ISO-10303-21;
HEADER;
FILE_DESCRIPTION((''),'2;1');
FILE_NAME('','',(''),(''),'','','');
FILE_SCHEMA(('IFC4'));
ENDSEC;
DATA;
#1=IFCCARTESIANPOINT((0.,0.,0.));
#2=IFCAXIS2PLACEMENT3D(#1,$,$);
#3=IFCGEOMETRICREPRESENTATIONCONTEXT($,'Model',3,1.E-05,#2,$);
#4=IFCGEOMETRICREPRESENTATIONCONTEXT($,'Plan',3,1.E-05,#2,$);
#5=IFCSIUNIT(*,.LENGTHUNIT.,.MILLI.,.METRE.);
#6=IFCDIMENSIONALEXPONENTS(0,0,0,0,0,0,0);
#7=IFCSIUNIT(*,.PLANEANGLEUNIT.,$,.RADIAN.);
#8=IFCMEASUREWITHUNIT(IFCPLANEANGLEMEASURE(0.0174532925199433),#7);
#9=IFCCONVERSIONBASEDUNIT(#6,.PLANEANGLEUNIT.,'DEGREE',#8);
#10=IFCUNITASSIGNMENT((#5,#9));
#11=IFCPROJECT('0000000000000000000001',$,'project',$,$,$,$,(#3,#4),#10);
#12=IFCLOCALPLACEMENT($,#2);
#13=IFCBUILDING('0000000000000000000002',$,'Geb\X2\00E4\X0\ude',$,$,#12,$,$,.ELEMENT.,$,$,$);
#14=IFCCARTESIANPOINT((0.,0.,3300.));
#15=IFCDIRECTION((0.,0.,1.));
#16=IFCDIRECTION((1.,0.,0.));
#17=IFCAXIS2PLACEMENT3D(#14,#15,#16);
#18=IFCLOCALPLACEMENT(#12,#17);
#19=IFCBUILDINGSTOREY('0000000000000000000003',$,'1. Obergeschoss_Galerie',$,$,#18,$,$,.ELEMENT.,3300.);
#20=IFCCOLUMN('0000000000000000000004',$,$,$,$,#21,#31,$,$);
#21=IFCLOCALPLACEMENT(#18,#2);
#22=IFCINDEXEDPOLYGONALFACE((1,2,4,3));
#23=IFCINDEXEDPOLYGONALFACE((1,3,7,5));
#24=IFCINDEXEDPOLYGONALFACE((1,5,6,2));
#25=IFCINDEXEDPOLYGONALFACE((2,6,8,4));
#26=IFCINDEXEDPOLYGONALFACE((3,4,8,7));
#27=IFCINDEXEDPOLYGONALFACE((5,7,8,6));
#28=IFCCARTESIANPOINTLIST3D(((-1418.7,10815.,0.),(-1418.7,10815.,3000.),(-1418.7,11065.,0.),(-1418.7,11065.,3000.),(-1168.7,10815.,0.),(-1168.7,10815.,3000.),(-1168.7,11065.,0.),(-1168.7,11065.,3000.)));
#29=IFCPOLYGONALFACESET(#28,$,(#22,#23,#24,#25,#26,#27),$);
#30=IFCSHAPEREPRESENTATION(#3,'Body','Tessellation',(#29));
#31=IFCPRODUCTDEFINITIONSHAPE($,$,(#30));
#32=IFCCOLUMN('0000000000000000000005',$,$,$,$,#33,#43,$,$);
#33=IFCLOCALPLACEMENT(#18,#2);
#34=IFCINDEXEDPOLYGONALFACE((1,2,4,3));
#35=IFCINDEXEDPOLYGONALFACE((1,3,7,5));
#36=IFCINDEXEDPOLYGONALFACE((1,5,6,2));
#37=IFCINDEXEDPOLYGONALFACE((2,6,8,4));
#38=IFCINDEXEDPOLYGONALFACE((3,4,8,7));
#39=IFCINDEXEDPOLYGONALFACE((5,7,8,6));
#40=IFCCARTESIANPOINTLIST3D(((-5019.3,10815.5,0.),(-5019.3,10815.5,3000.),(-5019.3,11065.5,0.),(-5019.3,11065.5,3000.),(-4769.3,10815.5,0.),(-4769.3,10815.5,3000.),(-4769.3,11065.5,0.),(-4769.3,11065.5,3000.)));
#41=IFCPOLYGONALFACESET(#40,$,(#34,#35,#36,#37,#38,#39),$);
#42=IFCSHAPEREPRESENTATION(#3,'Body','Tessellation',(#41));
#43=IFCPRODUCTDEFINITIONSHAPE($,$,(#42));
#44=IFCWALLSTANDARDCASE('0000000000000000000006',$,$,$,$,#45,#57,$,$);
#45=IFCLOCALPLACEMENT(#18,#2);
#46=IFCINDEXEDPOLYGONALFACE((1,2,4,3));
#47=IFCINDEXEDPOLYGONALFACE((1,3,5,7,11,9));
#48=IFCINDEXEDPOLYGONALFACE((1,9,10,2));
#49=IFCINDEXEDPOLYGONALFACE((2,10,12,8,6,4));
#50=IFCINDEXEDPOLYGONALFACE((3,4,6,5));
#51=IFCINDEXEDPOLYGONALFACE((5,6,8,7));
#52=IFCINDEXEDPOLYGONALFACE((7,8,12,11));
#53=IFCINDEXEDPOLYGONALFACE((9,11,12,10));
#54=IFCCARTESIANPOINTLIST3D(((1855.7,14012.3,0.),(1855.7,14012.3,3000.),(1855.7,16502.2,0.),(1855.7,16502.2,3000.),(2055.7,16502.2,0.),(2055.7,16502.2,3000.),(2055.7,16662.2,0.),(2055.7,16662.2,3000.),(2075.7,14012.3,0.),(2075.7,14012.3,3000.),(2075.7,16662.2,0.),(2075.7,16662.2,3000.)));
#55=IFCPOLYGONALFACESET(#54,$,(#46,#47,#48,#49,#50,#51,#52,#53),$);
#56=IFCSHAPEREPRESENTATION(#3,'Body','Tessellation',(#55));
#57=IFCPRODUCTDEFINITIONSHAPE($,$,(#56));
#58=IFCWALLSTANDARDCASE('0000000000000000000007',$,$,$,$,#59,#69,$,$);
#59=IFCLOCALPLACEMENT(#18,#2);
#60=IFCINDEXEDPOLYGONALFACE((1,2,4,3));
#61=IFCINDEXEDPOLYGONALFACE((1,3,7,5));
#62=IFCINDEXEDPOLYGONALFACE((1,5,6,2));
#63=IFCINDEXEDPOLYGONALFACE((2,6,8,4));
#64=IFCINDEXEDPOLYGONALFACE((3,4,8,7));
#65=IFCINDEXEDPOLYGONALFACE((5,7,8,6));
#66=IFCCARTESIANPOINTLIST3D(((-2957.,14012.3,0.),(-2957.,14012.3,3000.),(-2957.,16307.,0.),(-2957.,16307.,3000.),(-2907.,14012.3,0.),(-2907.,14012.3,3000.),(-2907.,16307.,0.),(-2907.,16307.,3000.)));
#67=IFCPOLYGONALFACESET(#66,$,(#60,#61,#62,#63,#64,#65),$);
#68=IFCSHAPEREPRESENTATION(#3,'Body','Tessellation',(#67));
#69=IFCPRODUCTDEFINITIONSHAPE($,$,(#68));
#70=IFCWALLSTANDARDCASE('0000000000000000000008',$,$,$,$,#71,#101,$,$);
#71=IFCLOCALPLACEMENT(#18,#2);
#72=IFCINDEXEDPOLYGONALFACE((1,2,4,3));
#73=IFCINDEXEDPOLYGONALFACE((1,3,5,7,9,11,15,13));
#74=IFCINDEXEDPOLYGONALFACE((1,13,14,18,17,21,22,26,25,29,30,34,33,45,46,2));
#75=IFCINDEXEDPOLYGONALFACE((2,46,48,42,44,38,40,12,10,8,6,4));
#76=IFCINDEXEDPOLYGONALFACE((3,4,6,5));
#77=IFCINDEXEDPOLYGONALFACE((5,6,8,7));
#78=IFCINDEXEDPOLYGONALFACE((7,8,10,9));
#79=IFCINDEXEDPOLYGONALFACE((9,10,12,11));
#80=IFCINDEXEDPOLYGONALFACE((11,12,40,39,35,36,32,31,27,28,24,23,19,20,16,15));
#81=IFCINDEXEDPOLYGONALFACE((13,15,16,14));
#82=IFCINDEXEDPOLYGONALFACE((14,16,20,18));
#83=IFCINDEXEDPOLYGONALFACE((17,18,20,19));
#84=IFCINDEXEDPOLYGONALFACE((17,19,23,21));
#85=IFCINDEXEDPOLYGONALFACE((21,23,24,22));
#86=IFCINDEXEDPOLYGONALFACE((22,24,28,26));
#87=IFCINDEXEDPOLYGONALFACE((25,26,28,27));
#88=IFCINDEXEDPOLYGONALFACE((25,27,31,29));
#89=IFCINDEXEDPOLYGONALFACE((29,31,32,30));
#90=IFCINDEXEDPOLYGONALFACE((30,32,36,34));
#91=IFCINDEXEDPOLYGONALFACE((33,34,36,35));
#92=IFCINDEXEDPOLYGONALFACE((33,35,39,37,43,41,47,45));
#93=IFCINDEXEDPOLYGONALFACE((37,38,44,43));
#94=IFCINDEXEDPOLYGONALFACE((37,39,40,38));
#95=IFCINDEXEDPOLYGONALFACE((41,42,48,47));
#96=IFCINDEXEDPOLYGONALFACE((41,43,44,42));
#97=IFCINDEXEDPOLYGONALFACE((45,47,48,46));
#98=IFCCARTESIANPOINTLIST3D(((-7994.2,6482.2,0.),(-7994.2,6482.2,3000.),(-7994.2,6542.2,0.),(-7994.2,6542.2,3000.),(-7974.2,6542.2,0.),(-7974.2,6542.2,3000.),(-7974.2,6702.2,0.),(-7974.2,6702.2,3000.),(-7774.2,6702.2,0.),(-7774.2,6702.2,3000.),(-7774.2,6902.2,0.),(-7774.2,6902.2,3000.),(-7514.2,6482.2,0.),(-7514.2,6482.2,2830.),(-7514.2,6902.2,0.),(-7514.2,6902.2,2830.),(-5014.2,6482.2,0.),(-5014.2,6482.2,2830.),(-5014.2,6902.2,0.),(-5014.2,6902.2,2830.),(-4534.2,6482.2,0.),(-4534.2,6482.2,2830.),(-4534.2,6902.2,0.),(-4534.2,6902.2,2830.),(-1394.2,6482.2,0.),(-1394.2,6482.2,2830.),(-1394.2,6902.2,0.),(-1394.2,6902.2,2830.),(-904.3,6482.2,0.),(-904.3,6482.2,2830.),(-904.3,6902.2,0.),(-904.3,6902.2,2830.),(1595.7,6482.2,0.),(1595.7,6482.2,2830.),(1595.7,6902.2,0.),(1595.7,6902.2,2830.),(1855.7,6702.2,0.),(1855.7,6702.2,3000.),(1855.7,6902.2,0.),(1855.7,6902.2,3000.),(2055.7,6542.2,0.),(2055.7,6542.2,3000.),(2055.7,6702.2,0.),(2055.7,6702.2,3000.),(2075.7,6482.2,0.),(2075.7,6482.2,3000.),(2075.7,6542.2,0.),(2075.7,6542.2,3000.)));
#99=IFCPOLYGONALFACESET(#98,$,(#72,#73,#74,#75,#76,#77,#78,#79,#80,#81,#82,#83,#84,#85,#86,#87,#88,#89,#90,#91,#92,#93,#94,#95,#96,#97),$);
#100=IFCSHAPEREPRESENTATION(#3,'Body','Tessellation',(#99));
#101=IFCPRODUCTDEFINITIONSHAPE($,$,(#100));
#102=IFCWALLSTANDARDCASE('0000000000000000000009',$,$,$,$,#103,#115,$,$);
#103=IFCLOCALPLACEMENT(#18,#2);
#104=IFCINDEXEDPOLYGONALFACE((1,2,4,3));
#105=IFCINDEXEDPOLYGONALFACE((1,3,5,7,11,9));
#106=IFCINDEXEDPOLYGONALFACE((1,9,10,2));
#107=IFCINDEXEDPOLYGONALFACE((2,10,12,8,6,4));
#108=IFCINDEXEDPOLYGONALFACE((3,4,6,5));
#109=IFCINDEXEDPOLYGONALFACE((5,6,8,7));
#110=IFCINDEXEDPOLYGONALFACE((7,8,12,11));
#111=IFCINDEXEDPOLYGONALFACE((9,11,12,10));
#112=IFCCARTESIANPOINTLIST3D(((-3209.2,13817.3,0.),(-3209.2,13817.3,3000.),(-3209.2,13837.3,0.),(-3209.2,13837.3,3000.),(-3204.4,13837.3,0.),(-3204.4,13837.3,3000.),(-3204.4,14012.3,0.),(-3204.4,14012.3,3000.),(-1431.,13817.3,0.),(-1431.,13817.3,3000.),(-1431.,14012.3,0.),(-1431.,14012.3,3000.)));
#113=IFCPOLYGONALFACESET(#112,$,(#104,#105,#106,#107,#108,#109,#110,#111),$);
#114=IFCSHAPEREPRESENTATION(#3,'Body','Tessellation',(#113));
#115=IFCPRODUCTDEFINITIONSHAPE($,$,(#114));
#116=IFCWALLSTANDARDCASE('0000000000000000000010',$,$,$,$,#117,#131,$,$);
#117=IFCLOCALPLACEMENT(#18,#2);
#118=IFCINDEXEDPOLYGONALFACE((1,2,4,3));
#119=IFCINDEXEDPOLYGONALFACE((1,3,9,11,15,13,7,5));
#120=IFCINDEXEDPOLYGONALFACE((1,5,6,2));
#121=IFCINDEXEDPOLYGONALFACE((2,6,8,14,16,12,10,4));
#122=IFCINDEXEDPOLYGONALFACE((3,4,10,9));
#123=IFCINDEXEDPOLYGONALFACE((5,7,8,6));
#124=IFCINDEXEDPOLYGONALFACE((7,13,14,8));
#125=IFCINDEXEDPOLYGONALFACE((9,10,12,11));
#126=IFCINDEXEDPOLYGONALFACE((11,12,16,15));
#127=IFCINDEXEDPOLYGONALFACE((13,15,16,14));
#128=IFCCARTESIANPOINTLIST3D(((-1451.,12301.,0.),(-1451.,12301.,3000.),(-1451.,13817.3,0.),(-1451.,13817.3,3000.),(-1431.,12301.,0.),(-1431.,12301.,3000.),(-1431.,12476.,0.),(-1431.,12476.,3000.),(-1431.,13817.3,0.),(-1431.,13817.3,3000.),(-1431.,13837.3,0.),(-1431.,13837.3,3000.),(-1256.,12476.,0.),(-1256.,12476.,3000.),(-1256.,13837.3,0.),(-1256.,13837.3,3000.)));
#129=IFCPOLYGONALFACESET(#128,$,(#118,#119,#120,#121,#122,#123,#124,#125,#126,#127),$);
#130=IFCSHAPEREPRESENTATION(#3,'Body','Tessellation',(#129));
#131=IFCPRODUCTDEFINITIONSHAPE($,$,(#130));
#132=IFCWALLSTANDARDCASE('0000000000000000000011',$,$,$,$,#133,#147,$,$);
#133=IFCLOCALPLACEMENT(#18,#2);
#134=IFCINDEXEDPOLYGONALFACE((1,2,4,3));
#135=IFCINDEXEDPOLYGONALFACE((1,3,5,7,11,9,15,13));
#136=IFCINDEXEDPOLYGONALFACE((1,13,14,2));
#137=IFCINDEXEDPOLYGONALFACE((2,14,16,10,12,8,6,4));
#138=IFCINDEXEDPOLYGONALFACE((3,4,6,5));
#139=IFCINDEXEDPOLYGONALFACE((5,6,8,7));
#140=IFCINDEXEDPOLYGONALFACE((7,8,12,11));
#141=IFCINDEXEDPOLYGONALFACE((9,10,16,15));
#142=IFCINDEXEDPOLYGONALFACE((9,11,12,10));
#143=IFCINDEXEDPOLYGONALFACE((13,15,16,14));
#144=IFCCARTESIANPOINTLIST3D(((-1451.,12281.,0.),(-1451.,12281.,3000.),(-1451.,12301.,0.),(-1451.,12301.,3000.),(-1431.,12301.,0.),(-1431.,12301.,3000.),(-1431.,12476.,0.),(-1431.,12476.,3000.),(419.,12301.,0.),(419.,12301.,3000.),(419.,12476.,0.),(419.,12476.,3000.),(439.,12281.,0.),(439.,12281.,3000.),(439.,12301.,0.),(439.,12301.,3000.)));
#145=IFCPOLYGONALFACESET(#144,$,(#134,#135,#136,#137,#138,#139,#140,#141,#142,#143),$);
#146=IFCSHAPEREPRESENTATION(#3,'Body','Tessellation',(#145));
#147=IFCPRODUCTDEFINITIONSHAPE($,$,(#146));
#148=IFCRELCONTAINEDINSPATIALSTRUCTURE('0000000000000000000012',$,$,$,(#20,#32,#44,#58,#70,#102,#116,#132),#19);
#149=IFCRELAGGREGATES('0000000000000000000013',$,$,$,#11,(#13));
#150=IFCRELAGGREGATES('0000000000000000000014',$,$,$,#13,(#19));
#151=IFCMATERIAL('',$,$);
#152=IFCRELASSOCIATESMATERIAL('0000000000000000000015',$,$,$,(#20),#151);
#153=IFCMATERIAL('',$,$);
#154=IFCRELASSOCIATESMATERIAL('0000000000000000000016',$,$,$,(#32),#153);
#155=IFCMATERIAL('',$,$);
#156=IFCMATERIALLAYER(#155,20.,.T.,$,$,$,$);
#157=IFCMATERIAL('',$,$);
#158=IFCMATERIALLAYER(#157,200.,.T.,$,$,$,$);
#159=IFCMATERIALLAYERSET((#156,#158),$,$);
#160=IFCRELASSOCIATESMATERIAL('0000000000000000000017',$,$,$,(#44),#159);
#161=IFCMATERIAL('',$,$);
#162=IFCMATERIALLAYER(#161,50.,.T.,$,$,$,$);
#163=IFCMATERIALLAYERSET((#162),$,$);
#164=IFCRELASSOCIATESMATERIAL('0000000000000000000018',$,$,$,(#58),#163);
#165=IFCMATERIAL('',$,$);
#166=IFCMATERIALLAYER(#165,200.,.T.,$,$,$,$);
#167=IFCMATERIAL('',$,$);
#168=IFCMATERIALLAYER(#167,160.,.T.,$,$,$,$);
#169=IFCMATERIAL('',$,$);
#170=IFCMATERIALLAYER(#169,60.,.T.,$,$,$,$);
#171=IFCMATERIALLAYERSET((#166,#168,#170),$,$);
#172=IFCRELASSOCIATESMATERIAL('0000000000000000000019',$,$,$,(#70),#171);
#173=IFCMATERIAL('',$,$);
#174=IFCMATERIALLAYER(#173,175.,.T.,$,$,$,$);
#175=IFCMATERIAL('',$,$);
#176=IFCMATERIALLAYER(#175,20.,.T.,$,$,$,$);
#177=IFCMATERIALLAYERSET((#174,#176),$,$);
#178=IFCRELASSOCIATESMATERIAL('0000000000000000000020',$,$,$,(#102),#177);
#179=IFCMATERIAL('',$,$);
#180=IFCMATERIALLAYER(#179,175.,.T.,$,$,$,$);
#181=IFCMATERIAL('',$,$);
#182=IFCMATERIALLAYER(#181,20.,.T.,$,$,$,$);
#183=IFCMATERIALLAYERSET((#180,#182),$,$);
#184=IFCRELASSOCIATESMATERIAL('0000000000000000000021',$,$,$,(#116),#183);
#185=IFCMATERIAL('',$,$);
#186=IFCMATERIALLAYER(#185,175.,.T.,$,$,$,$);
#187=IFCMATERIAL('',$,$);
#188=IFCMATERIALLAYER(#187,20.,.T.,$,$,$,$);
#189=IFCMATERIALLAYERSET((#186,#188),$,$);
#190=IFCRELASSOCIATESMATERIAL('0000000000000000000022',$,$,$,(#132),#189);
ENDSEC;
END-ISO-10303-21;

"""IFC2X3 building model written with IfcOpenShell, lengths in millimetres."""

from ifc_helpers import new_model, entity, si_unit, converted_unit, frame, frame_2d, origin, origin_with_axes, place, context, project, spatial, polyline, rectangle, outline, extrude, material, layer, layer_set, layer_usage, element, save


model = new_model("IFC2X3")

# Units and contexts
model_context = context("Model", 3, precision=1e-05, world=origin())
plan_context = context("Plan", 3, precision=1e-05, world=origin())
ifc_project = project(units=[si_unit("LENGTHUNIT", "METRE", prefix="MILLI"), converted_unit("PLANEANGLEUNIT", "DEGREE", entity("IfcPlaneAngleMeasure", 0.0174532925199433), si_unit("PLANEANGLEUNIT", "RADIAN"), dimensions=[0, 0, 0, 0, 0, 0, 0])], contexts=[model_context, plan_context])

# Building, storey
building_placement = place(None, origin())
building = spatial("IfcBuilding", under=ifc_project, at=building_placement, Name="Gebäude", CompositionType="ELEMENT")
storey_placement = place(building_placement, frame((0.0, 0.0, 3300.0), z_axis=(0.0, 0.0, 1.0), x_axis=(1.0, 0.0, 0.0)))
storey = spatial("IfcBuildingStorey", under=building, at=storey_placement, Name="1. Obergeschoss_Galerie", CompositionType="ELEMENT", Elevation=3300.0)

# Columns
ifc_material_1 = material(Name="")
column_1_placement = place(storey_placement, frame((-1418.7, 10815.0, 0.0), z_axis=(0.0, 0.0, 1.0), x_axis=(1.0, 0.0, 0.0)))
element("IfcColumn", 1, at=column_1_placement, inside=storey, material=ifc_material_1, context=model_context, shape_type="SweptSolid", body=[
    extrude(rectangle(XDim=250.0, YDim=250.0, at=frame_2d((125.0, 125.0), x_axis=(1.0, 0.0))), origin_with_axes(), (0.0, 0.0, 1.0), 3000.0),
])
ifc_material_2 = material(Name="")
column_2_placement = place(storey_placement, frame((-5019.3, 10815.5, 0.0), z_axis=(0.0, 0.0, 1.0), x_axis=(1.0, 0.0, 0.0)))
element("IfcColumn", 2, at=column_2_placement, inside=storey, material=ifc_material_2, context=model_context, shape_type="SweptSolid", body=[
    extrude(rectangle(XDim=250.0, YDim=250.0, at=frame_2d((125.0, 125.0), x_axis=(1.0, 0.0))), origin_with_axes(), (0.0, 0.0, 1.0), 3000.0),
])

# Walls
ifc_material_3 = material(Name="")
ifc_layer_1 = layer(ifc_material_3, 20.0, ventilated=True)
ifc_material_4 = material(Name="")
ifc_layer_2 = layer(ifc_material_4, 200.0, ventilated=True)
ifc_layer_set_1 = layer_set([ifc_layer_1, ifc_layer_2])
ifc_layer_usage_1 = layer_usage(ifc_layer_set_1, "AXIS2", "POSITIVE", 0.0)
wall_1_placement = place(storey_placement, frame((2075.7, 14012.3, 0.0), z_axis=(0.0, 0.0, 1.0), x_axis=(0.0, 1.0, 0.0)))
element("IfcWallStandardCase", 3, at=wall_1_placement, inside=storey, material=ifc_layer_usage_1, context=model_context, shape_type="SweptSolid", body=[
    extrude(outline(polyline([(0.0, 0.0), (2649.9, 0.0), (2649.9, 20.0), (2489.9, 20.0), (2489.9, 220.0), (0.0, 220.0), (0.0, 0.0)])), origin_with_axes(), (0.0, 0.0, 1.0), 3000.0),
])
ifc_material_5 = material(Name="")
ifc_layer_3 = layer(ifc_material_5, 50.0, ventilated=True)
ifc_layer_set_2 = layer_set([ifc_layer_3])
ifc_layer_usage_2 = layer_usage(ifc_layer_set_2, "AXIS2", "POSITIVE", 0.0)
wall_2_placement = place(storey_placement, frame((-2957.0, 16307.0, 0.0), z_axis=(0.0, 0.0, 1.0), x_axis=(0.0, -1.0, 0.0)))
element("IfcWallStandardCase", 4, at=wall_2_placement, inside=storey, material=ifc_layer_usage_2, context=model_context, shape_type="SweptSolid", body=[
    extrude(rectangle(XDim=2294.6, YDim=50.0, at=frame_2d((1147.3, 25.0), x_axis=(1.0, 0.0))), origin_with_axes(), (0.0, 0.0, 1.0), 3000.0),
])

# Wall, openings
ifc_material_6 = material(Name="")
ifc_layer_4 = layer(ifc_material_6, 200.0, ventilated=True)
ifc_material_7 = material(Name="")
ifc_layer_5 = layer(ifc_material_7, 160.0, ventilated=True)
ifc_material_8 = material(Name="")
ifc_layer_6 = layer(ifc_material_8, 60.0, ventilated=True)
ifc_layer_set_3 = layer_set([ifc_layer_4, ifc_layer_5, ifc_layer_6])
ifc_layer_usage_3 = layer_usage(ifc_layer_set_3, "AXIS2", "POSITIVE", -420.0)
wall_3_placement = place(storey_placement, frame((1855.7, 6902.2, 0.0), z_axis=(0.0, 0.0, 1.0), x_axis=(-1.0, 0.0, 0.0)))
wall_3 = element("IfcWallStandardCase", 5, at=wall_3_placement, inside=storey, material=ifc_layer_usage_3, context=model_context, shape_type="SweptSolid", body=[
    extrude(outline(polyline([(0.0, 0.0), (9630.0, 0.0), (9630.0, 200.0), (9830.0, 200.0), (9830.0, 360.0), (9850.0, 360.0), (9850.0, 420.0), (-220.0, 420.0), (-220.0, 360.0), (-200.0, 360.0), (-200.0, 200.0), (0.0, 200.0), (0.0, 0.0)])), origin_with_axes(), (0.0, 0.0, 1.0), 3000.0),
])
opening_1_placement = place(wall_3_placement, frame((6870.0, 0.0, 0.0), z_axis=(0.0, 1.0, 0.0), x_axis=(0.0, 0.0, 1.0)))
element("IfcOpeningElement", 6, at=opening_1_placement, cuts=wall_3, ObjectType="Opening", context=model_context, shape_type="SweptSolid", body=[
    extrude(rectangle(XDim=2830.0, YDim=2500.0, at=frame_2d((1415.0, 1250.0), x_axis=(1.0, 0.0))), origin_with_axes(), (0.0, 0.0, 1.0), 420.0),
])
opening_2_placement = place(wall_3_placement, frame((3250.0, 0.0, 0.0), z_axis=(0.0, 1.0, 0.0), x_axis=(0.0, 0.0, 1.0)))
element("IfcOpeningElement", 7, at=opening_2_placement, cuts=wall_3, ObjectType="Opening", context=model_context, shape_type="SweptSolid", body=[
    extrude(rectangle(XDim=2830.0, YDim=3140.0, at=frame_2d((1415.0, 1570.0), x_axis=(1.0, 0.0))), origin_with_axes(), (0.0, 0.0, 1.0), 420.0),
])
opening_3_placement = place(wall_3_placement, frame((260.0, 0.0, 0.0), z_axis=(0.0, 1.0, 0.0), x_axis=(0.0, 0.0, 1.0)))
element("IfcOpeningElement", 8, at=opening_3_placement, cuts=wall_3, ObjectType="Opening", context=model_context, shape_type="SweptSolid", body=[
    extrude(rectangle(XDim=2830.0, YDim=2500.0, at=frame_2d((1415.0, 1250.0), x_axis=(1.0, 0.0))), origin_with_axes(), (0.0, 0.0, 1.0), 420.0),
])

# Walls
ifc_material_9 = material(Name="")
ifc_layer_7 = layer(ifc_material_9, 175.0, ventilated=True)
ifc_material_10 = material(Name="")
ifc_layer_8 = layer(ifc_material_10, 20.0, ventilated=True)
ifc_layer_set_4 = layer_set([ifc_layer_7, ifc_layer_8])
ifc_layer_usage_4 = layer_usage(ifc_layer_set_4, "AXIS2", "POSITIVE", -195.0)
wall_4_placement = place(storey_placement, frame((-3209.2, 13817.3, 0.0), z_axis=(0.0, 0.0, 1.0), x_axis=(1.0, 0.0, 0.0)))
element("IfcWallStandardCase", 9, at=wall_4_placement, inside=storey, material=ifc_layer_usage_4, context=model_context, shape_type="SweptSolid", body=[
    extrude(outline(polyline([(4.8, 195.0), (4.8, 20.0), (0.0, 20.0), (0.0, 0.0), (1778.2, 0.0), (1778.2, 195.0), (4.8, 195.0)])), origin_with_axes(), (0.0, 0.0, 1.0), 3000.0),
])
ifc_material_11 = material(Name="")
ifc_layer_9 = layer(ifc_material_11, 175.0, ventilated=True)
ifc_material_12 = material(Name="")
ifc_layer_10 = layer(ifc_material_12, 20.0, ventilated=True)
ifc_layer_set_5 = layer_set([ifc_layer_9, ifc_layer_10])
ifc_layer_usage_5 = layer_usage(ifc_layer_set_5, "AXIS2", "POSITIVE", 0.0)
wall_5_placement = place(storey_placement, frame((-1451.0, 13817.3, 0.0), z_axis=(0.0, 0.0, 1.0), x_axis=(0.0, -1.0, 0.0)))
element("IfcWallStandardCase", 10, at=wall_5_placement, inside=storey, material=ifc_layer_usage_5, context=model_context, shape_type="SweptSolid", body=[
    extrude(outline(polyline([(0.0, 0.0), (1516.4, 0.0), (1516.4, 20.0), (1341.4, 20.0), (1341.4, 195.0), (-20.0, 195.0), (-20.0, 20.0), (0.0, 20.0), (0.0, 0.0)])), origin_with_axes(), (0.0, 0.0, 1.0), 3000.0),
])
ifc_material_13 = material(Name="")
ifc_layer_11 = layer(ifc_material_13, 175.0, ventilated=True)
ifc_material_14 = material(Name="")
ifc_layer_12 = layer(ifc_material_14, 20.0, ventilated=True)
ifc_layer_set_6 = layer_set([ifc_layer_11, ifc_layer_12])
ifc_layer_usage_6 = layer_usage(ifc_layer_set_6, "AXIS2", "POSITIVE", 0.0)
wall_6_placement = place(storey_placement, frame((-1451.0, 12281.0, 0.0), z_axis=(0.0, 0.0, 1.0), x_axis=(1.0, 0.0, 0.0)))
element("IfcWallStandardCase", 11, at=wall_6_placement, inside=storey, material=ifc_layer_usage_6, context=model_context, shape_type="SweptSolid", body=[
    extrude(outline(polyline([(0.0, 0.0), (1890.0, 0.0), (1890.0, 20.0), (1870.0, 20.0), (1870.0, 195.0), (20.0, 195.0), (20.0, 20.0), (0.0, 20.0), (0.0, 0.0)])), origin_with_axes(), (0.0, 0.0, 1.0), 3000.0),
])

save(model, "model.ifc")
